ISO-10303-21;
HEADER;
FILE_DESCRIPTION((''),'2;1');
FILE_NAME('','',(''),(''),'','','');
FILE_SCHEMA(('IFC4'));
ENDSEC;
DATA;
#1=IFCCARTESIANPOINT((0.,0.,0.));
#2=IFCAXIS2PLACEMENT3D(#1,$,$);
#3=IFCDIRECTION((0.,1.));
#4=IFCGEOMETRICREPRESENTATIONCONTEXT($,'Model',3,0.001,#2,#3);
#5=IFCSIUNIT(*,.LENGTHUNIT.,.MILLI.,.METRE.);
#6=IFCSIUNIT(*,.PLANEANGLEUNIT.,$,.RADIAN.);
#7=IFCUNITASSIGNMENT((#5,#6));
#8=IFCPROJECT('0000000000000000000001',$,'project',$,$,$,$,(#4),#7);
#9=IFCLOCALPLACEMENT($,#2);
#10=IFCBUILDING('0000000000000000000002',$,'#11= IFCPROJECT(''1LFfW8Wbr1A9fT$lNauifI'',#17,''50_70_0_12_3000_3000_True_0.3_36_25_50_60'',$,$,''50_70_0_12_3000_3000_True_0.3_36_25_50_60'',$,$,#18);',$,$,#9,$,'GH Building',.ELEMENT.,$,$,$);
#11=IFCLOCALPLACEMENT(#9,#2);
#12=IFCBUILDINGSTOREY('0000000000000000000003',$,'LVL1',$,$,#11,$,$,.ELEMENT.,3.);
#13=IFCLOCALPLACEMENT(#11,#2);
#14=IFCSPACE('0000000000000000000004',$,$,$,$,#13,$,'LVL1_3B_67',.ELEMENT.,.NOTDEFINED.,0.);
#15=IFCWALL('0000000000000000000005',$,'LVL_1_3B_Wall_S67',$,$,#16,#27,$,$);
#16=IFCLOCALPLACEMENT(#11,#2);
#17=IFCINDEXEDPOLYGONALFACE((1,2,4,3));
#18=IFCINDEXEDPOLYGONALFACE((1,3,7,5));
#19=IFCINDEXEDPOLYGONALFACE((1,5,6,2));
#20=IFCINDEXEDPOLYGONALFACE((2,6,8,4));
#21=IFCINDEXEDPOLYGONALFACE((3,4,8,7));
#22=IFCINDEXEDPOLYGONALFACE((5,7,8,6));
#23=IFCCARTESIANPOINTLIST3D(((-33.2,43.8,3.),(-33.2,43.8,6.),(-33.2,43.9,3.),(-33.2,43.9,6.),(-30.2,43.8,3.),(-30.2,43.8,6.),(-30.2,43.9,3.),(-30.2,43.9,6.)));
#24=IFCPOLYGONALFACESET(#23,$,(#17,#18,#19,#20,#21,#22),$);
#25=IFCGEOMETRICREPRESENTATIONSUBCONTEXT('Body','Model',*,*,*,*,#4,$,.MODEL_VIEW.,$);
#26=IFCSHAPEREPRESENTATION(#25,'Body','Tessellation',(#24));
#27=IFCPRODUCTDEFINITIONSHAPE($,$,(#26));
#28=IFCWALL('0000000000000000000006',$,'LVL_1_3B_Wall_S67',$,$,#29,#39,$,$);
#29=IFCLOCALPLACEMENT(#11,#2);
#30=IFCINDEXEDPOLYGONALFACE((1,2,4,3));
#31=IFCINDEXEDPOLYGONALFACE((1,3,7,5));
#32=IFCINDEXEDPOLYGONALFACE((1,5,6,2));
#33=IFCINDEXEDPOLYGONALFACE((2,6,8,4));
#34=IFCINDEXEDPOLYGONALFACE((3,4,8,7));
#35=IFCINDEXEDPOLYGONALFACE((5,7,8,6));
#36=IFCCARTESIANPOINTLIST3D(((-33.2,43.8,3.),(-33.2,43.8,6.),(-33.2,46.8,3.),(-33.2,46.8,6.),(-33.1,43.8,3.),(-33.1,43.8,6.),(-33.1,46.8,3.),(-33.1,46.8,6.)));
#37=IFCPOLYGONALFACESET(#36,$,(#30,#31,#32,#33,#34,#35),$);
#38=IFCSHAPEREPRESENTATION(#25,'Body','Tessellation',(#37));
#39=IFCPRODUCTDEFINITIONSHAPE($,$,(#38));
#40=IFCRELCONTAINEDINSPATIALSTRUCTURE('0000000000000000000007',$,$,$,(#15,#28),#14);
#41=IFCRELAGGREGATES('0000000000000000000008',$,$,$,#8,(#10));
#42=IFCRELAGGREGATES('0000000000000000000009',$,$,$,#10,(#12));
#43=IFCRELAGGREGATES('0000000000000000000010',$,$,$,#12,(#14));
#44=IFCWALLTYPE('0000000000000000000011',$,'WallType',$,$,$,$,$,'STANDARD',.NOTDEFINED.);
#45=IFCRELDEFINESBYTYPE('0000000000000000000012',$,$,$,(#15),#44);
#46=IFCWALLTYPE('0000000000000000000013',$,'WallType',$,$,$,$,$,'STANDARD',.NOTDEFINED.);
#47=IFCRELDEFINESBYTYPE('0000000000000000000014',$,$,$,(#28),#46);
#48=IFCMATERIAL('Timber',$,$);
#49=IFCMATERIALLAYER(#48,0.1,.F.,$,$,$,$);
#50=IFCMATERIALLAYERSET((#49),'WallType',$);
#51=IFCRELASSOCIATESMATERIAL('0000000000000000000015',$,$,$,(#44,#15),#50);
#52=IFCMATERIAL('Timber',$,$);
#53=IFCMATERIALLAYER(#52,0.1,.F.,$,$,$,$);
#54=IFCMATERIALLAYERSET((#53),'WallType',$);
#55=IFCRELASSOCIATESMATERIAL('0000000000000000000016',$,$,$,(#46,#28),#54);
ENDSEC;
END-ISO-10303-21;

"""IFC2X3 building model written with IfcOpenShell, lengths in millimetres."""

from ifc_helpers import new_model, si_unit, direction, frame, frame_2d, origin, place, context, subcontext, project, spatial, rectangle, extrude, material, layer, layer_set, layer_usage, type_object, element, save


model = new_model("IFC2X3")

# Units and contexts
model_context = context("Model", 3, precision=0.001, world=origin(), true_north=direction((0.0, 1.0)))
body_context = subcontext(model_context, "Body", "Model", "MODEL_VIEW")
ifc_project = project(units=[si_unit("LENGTHUNIT", "METRE", prefix="MILLI"), si_unit("PLANEANGLEUNIT", "RADIAN")], contexts=[model_context])

# Building, storey
building_placement = place(None, origin())
building = spatial("IfcBuilding", under=ifc_project, at=building_placement, Name="#11= IFCPROJECT('1LFfW8Wbr1A9fT$lNauifI',#17,'50_70_0_12_3000_3000_True_0.3_36_25_50_60',$,$,'50_70_0_12_3000_3000_True_0.3_36_25_50_60',$,$,#18);", LongName="GH Building", CompositionType="ELEMENT")
storey_placement = place(building_placement, origin())
storey = spatial("IfcBuildingStorey", under=building, at=storey_placement, Name="LVL1", CompositionType="ELEMENT", Elevation=3.0)

# Shared definitions
space_1_placement = place(storey_placement, origin())
space_1 = spatial("IfcSpace", under=storey, at=space_1_placement, LongName="LVL1_3B_67", CompositionType="ELEMENT", InteriorOrExteriorSpace="NOTDEFINED", ElevationWithFlooring=0.0)

# Walls
ifc_material_1 = material(Name="Timber")
ifc_layer_1 = layer(ifc_material_1, 0.1, ventilated=False)
ifc_layer_set_1 = layer_set([ifc_layer_1], Name="WallType")
ifc_layer_usage_1 = layer_usage(ifc_layer_set_1, "AXIS2", "NEGATIVE", 0.0)
wall_type_1 = type_object("IfcWallType", Name="WallType", ElementType="STANDARD", PredefinedType="NOTDEFINED", material=ifc_layer_set_1)
wall_1_placement = place(space_1_placement, frame((-30.2, 43.8, 3.0), z_axis=(0.0, 0.0, 1.0), x_axis=(-1.0, 0.0, 0.0)))
element("IfcWall", 1, at=wall_1_placement, inside=space_1, type_object=wall_type_1, material=ifc_layer_usage_1, Name="LVL_1_3B_Wall_S67", context=body_context, shape_type="SweptSolid", body=[
    extrude(rectangle(XDim=3.0, YDim=0.1, at=frame_2d((1.5, -0.1))), origin(), (0.0, 0.0, 1.0), 3.0),
])
ifc_material_2 = material(Name="Timber")
ifc_layer_2 = layer(ifc_material_2, 0.1, ventilated=False)
ifc_layer_set_2 = layer_set([ifc_layer_2], Name="WallType")
ifc_layer_usage_2 = layer_usage(ifc_layer_set_2, "AXIS2", "NEGATIVE", 0.0)
wall_type_2 = type_object("IfcWallType", Name="WallType", ElementType="STANDARD", PredefinedType="NOTDEFINED", material=ifc_layer_set_2)
wall_2_placement = place(space_1_placement, frame((-33.2, 43.8, 3.0), z_axis=(0.0, 0.0, 1.0), x_axis=(0.0, 1.0, 0.0)))
element("IfcWall", 2, at=wall_2_placement, inside=space_1, type_object=wall_type_2, material=ifc_layer_usage_2, Name="LVL_1_3B_Wall_S67", context=body_context, shape_type="SweptSolid", body=[
    extrude(rectangle(XDim=3.0, YDim=0.1, at=frame_2d((1.5, -0.1))), origin(), (0.0, 0.0, 1.0), 3.0),
])

save(model, "model.ifc")
